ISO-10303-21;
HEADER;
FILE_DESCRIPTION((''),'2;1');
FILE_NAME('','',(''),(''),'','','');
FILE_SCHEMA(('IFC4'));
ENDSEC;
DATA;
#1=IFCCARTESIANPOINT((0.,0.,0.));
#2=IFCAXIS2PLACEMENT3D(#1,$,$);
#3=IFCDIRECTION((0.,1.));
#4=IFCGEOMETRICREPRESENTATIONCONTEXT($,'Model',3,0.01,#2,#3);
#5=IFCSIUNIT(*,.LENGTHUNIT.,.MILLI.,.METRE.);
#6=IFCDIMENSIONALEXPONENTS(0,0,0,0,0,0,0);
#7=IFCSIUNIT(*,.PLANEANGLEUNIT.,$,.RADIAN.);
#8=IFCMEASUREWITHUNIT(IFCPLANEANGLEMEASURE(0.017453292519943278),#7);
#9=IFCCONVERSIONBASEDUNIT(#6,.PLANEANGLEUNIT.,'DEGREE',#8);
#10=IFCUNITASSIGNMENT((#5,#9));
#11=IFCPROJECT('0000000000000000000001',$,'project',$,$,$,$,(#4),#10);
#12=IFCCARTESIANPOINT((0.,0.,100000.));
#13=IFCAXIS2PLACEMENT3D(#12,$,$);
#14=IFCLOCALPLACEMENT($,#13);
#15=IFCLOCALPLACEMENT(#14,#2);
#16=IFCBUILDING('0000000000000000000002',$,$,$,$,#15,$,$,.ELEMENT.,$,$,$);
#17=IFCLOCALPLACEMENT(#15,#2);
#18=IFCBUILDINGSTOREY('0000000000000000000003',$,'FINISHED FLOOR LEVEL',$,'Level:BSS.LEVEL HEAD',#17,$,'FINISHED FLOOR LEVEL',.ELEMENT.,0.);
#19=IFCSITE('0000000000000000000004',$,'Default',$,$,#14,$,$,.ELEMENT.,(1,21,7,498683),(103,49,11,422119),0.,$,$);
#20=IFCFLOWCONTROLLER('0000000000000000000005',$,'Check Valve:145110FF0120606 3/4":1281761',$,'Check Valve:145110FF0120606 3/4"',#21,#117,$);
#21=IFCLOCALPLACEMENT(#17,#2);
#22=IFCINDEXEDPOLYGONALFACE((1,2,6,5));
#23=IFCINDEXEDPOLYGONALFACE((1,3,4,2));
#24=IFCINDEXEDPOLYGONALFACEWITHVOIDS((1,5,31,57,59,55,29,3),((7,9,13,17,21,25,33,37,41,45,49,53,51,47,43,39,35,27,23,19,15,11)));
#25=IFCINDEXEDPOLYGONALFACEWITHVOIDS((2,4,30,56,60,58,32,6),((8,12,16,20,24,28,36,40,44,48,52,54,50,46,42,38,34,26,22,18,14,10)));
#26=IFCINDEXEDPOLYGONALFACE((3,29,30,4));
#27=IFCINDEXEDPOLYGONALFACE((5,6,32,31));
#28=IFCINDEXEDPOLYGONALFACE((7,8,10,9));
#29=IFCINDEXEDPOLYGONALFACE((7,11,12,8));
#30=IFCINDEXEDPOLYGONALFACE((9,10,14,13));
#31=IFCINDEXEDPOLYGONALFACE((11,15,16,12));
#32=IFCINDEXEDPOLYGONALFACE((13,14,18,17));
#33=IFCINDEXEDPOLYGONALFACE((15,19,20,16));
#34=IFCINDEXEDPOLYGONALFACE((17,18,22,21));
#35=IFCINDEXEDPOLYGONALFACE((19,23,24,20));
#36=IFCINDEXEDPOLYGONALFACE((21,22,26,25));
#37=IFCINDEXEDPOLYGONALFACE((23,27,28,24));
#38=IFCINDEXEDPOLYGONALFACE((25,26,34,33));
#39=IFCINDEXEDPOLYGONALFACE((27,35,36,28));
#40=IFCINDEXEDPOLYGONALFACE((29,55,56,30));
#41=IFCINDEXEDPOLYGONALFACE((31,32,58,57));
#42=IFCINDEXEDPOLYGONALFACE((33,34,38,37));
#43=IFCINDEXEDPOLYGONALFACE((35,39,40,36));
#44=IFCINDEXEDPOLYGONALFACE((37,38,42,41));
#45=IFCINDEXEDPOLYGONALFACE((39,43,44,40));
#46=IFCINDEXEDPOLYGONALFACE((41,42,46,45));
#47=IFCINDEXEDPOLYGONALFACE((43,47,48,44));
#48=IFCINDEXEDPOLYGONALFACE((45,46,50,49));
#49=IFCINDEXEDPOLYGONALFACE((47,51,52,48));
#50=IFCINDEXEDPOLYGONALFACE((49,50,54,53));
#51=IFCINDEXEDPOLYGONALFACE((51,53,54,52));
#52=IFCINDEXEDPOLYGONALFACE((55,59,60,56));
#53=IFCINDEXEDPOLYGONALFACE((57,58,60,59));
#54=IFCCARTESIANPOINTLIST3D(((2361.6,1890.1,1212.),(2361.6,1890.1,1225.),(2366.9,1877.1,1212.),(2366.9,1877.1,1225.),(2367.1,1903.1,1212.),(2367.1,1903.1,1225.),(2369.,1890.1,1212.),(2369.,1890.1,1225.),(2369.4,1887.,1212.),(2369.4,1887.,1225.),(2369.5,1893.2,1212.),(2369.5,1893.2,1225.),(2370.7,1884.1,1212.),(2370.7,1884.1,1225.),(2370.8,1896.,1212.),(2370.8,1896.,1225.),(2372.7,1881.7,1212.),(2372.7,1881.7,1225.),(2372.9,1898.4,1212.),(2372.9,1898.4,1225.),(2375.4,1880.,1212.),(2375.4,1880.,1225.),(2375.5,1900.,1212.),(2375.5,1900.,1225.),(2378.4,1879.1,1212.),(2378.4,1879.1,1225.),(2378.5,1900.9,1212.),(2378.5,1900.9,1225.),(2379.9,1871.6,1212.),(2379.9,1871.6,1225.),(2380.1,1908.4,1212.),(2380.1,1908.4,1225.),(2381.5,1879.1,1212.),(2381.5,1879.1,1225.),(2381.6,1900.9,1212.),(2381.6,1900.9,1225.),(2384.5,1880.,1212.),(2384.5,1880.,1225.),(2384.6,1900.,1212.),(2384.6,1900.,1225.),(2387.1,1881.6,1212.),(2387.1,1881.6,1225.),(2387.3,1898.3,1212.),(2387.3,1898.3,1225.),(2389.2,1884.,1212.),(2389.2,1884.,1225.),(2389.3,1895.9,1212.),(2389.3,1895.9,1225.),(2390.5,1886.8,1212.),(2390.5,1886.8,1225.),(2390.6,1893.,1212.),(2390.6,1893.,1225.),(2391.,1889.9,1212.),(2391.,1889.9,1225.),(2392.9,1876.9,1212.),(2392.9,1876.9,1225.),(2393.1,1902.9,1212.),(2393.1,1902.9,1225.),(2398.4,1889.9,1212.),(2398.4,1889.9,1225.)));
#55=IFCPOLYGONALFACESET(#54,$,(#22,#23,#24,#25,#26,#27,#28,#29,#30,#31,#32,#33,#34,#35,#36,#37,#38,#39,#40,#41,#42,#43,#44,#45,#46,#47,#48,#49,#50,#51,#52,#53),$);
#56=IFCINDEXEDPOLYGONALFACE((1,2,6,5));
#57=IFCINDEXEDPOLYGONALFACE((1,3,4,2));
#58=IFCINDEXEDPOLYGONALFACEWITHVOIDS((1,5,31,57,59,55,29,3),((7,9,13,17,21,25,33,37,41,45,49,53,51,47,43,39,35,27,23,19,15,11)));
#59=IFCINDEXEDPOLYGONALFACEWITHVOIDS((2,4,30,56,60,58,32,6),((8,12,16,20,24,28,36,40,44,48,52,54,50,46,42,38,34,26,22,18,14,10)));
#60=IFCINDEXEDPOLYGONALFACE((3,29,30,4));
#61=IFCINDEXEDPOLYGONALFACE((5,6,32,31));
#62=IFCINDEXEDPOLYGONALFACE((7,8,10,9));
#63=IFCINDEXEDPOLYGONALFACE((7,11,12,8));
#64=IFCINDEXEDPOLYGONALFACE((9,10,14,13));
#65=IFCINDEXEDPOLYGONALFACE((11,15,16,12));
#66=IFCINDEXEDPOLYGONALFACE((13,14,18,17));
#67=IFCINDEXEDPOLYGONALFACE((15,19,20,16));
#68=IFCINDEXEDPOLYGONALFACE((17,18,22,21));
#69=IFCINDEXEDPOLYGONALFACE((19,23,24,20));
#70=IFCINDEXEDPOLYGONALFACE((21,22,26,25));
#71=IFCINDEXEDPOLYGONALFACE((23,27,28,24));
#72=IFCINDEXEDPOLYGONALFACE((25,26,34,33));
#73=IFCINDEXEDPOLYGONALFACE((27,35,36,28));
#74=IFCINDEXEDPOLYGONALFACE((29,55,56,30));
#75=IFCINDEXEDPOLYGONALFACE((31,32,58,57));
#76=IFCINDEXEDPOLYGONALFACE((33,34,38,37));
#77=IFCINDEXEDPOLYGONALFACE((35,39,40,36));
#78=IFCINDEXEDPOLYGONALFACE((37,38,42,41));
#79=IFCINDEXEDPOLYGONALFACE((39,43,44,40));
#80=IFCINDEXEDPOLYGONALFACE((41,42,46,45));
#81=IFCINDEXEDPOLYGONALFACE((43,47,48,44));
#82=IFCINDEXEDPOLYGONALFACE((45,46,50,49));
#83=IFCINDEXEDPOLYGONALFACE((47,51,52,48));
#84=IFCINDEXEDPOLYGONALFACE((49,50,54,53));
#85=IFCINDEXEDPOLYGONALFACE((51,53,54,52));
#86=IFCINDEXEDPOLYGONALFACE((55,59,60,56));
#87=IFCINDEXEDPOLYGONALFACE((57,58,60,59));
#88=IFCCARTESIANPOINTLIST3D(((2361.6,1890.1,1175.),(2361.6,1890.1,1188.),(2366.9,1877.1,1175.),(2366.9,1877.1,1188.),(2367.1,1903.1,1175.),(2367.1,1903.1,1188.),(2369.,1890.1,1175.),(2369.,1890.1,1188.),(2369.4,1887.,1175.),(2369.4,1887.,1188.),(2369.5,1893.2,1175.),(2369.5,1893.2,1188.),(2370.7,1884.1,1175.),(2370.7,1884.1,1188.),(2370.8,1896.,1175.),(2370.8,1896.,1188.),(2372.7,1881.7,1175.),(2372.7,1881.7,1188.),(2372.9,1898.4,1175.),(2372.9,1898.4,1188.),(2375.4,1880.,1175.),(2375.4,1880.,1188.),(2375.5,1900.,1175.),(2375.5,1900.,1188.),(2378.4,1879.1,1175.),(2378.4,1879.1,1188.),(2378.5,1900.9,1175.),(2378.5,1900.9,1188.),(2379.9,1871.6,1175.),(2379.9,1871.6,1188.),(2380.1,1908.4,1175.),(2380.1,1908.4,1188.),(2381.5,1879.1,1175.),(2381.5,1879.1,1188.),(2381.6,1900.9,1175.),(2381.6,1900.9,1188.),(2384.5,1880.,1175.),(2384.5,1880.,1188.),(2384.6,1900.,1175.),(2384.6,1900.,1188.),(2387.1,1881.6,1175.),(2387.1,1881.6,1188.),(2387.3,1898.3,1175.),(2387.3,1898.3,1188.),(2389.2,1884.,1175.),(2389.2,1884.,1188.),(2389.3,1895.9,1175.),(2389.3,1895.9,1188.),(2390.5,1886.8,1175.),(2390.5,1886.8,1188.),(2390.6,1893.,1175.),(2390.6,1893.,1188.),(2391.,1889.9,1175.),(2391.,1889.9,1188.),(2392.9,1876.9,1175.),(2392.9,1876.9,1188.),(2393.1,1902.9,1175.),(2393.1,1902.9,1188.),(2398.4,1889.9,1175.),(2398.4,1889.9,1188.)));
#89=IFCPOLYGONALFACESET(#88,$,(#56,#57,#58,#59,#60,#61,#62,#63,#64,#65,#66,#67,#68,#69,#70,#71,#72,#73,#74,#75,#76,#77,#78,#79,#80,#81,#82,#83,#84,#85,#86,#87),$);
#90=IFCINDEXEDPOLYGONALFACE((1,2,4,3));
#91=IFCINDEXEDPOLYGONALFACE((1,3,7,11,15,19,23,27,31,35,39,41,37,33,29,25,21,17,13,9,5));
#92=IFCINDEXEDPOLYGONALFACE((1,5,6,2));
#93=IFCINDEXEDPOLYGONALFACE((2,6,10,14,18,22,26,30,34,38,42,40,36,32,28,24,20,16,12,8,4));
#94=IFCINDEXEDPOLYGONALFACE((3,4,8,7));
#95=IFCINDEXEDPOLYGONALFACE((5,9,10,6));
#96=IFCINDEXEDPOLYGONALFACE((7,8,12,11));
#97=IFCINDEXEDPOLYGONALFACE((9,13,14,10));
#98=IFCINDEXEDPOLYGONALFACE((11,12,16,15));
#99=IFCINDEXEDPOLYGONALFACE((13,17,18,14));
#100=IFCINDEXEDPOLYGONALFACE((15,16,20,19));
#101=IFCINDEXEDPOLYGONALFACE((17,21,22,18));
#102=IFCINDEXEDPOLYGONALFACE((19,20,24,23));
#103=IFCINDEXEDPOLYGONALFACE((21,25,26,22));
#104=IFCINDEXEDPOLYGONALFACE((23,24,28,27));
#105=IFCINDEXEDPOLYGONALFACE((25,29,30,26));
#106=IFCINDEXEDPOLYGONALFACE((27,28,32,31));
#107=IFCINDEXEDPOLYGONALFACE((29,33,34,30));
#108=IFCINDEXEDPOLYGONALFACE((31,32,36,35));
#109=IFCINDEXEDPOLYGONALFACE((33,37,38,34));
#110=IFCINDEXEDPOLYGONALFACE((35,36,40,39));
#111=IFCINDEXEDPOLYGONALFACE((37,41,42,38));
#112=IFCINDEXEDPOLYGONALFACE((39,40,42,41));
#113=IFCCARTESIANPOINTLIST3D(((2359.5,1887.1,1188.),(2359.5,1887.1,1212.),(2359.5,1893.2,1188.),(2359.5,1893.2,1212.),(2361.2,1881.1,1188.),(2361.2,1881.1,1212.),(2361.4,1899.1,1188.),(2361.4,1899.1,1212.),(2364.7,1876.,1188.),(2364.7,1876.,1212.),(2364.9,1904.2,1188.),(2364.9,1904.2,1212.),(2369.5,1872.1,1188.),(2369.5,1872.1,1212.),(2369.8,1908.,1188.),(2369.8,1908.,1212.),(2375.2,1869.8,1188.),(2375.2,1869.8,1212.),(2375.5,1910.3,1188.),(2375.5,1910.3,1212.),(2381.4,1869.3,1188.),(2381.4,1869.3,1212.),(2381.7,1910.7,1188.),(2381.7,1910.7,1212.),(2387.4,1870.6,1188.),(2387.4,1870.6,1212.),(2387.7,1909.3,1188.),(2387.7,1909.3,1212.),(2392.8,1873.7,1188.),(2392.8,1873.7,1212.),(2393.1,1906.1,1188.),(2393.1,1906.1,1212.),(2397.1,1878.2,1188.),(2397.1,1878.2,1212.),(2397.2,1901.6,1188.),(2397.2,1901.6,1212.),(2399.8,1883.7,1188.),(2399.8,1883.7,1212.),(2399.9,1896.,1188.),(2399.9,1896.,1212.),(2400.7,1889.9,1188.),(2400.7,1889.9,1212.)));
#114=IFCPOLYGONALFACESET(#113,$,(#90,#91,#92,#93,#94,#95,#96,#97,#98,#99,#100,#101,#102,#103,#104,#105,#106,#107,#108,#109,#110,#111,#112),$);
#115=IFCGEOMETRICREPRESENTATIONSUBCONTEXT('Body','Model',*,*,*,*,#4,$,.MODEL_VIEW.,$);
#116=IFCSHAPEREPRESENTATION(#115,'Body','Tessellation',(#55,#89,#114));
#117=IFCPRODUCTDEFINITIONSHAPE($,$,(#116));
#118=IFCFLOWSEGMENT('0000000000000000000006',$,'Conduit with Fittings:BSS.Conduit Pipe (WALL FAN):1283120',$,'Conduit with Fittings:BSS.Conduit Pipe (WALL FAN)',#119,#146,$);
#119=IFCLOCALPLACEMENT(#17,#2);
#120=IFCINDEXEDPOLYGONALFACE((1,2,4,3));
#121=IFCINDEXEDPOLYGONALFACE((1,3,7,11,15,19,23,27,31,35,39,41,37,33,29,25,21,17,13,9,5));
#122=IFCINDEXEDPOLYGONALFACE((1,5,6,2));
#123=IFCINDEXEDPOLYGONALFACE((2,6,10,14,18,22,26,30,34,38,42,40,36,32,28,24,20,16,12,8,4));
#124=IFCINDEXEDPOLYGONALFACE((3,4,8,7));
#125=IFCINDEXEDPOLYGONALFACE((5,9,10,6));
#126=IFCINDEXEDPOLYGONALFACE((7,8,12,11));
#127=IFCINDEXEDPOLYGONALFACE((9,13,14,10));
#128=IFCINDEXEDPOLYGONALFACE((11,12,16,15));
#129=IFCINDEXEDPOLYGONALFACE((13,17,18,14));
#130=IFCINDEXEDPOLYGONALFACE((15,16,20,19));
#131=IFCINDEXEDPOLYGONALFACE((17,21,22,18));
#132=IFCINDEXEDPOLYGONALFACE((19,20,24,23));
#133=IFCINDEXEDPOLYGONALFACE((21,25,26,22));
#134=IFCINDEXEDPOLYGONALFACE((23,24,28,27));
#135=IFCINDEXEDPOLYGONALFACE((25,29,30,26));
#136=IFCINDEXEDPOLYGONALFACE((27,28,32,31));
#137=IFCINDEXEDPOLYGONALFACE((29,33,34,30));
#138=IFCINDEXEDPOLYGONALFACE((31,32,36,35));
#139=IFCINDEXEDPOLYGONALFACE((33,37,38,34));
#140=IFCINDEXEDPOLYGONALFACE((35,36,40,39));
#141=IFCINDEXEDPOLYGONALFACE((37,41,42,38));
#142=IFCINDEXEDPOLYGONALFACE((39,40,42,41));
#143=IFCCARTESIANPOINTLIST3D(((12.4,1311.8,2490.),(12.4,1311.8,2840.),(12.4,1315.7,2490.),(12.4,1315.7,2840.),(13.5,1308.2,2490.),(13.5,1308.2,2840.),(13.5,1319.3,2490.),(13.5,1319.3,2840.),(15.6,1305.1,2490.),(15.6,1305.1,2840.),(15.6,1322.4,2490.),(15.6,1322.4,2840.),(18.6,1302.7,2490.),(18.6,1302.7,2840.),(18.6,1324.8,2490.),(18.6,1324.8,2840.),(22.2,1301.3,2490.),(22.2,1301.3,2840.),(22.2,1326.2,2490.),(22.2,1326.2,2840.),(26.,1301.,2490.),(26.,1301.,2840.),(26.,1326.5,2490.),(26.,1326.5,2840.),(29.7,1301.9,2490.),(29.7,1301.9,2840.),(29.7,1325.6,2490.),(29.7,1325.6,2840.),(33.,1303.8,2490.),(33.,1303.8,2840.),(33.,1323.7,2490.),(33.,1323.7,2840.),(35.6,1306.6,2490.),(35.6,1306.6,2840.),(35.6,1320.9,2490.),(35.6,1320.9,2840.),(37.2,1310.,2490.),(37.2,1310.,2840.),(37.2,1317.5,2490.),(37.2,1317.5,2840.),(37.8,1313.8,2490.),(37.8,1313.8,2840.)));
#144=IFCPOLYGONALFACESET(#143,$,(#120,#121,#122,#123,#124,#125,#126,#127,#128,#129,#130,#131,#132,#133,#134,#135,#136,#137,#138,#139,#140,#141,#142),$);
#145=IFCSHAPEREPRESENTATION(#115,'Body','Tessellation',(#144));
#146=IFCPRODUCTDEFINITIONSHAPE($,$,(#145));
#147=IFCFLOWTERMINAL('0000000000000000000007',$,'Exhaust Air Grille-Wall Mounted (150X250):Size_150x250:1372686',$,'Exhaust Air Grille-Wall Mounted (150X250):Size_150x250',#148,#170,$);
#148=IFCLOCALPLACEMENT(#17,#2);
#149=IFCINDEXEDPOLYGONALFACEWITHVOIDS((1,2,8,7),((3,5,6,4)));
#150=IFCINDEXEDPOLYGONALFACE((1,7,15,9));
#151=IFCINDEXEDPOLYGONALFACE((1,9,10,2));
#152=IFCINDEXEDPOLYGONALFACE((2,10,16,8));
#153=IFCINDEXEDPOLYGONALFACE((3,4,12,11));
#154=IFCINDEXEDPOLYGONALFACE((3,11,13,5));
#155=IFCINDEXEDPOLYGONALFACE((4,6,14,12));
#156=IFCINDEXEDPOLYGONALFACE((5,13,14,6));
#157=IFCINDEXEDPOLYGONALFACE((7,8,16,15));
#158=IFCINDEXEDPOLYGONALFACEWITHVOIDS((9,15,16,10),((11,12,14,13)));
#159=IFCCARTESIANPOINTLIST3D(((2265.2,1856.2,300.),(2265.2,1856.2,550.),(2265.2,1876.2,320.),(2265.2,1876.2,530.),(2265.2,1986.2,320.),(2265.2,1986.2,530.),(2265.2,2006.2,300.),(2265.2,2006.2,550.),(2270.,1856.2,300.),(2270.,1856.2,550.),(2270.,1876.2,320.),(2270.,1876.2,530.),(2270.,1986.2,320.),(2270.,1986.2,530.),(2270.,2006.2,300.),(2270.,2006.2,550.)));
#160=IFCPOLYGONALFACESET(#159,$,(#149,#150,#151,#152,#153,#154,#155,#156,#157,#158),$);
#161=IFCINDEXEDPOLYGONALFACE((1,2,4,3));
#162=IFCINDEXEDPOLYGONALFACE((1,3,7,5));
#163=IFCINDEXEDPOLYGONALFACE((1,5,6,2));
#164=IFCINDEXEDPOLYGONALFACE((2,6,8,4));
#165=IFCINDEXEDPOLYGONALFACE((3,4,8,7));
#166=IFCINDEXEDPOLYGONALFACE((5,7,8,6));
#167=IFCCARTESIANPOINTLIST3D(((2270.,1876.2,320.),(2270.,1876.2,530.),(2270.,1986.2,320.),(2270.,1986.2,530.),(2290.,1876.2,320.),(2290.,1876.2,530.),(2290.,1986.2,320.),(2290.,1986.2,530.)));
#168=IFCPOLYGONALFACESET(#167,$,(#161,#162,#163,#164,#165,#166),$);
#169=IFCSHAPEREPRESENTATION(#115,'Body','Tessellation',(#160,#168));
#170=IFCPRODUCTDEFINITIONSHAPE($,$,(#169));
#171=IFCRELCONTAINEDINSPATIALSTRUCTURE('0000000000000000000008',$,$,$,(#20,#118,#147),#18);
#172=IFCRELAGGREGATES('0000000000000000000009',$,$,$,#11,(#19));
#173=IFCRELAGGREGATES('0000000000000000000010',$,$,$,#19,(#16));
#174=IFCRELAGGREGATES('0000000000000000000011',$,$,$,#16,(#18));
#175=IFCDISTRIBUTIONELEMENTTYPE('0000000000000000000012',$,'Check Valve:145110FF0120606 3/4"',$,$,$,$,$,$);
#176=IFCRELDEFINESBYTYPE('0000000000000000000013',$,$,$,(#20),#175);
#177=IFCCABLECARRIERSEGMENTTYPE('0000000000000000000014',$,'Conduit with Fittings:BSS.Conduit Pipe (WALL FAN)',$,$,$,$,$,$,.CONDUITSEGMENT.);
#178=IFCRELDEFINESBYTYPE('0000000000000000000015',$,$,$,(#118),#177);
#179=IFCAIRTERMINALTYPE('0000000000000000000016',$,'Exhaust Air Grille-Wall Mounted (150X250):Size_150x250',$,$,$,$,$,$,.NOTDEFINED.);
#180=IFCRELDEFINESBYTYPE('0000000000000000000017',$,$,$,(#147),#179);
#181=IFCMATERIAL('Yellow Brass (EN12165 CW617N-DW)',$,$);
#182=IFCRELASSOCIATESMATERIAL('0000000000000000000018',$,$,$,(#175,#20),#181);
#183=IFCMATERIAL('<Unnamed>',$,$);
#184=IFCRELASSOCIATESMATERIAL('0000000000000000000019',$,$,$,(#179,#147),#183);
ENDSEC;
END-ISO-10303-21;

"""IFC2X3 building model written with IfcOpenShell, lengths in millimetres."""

from ifc_helpers import new_model, entity, si_unit, converted_unit, direction, frame, frame_2d, origin, origin_2d_with_axis, place, context, subcontext, project, spatial, polyline, circle_curve, parameter, trimmed, segment, composite_curve, rectangle, circle, outline, extrude, source, transform, mapped, material, type_object, type_shapes, element, save


model = new_model("IFC2X3")

# Units and contexts
model_context = context("Model", 3, precision=0.01, world=origin(), true_north=direction((0.0, 1.0)))
body_context = subcontext(model_context, "Body", "Model", "MODEL_VIEW")
ifc_project = project(units=[si_unit("LENGTHUNIT", "METRE", prefix="MILLI"), converted_unit("PLANEANGLEUNIT", "DEGREE", entity("IfcPlaneAngleMeasure", 0.017453292519943278), si_unit("PLANEANGLEUNIT", "RADIAN"), dimensions=[0, 0, 0, 0, 0, 0, 0])], contexts=[model_context])

# Site, building, storey
site_placement = place(None, frame((0.0, 0.0, 100000.0)))
site = spatial("IfcSite", under=ifc_project, at=site_placement, Name="Default", CompositionType="ELEMENT", RefLatitude=(1, 21, 7, 498683), RefLongitude=(103, 49, 11, 422119), RefElevation=0.0)
building_placement = place(site_placement, origin())
building = spatial("IfcBuilding", under=site, at=building_placement, CompositionType="ELEMENT")
storey_placement = place(building_placement, origin())
storey = spatial("IfcBuildingStorey", under=building, at=storey_placement, Name="FINISHED FLOOR LEVEL", ObjectType="Level:BSS.LEVEL HEAD", LongName="FINISHED FLOOR LEVEL", CompositionType="ELEMENT", Elevation=0.0)

# Shared definitions
ifc_material_1 = material(Name="<Unnamed>")

# Flow controller
ifc_material_2 = material(Name="Yellow Brass (EN12165 CW617N-DW)")
distribution_element_type_1 = type_object("IfcDistributionElementType", Name="Check Valve:145110FF0120606 3/4\"", material=ifc_material_2)
shared_shape_1 = source(origin(), body_context, "Body", "SweptSolid", [
    extrude(outline(polyline([(-7.0, -17.0), (7.0, -17.0), (17.0, -7.0), (17.0, 7.0), (7.0, 17.0), (-7.0, 17.0), (-17.0, 7.0), (-17.0, -7.0), (-7.0, -17.0)]), holes=[composite_curve([segment(trimmed(circle_curve(frame_2d((0.0, 0.0), x_axis=(-0.382683, 0.92388)), 11.0), [parameter(0.0)], [parameter(180.0)], True, "PARAMETER"), False, "CONTINUOUS"), segment(trimmed(circle_curve(frame_2d((0.0, 0.0), x_axis=(-0.382683, 0.92388)), 11.0), [parameter(180.0)], [parameter(0.0)], True, "PARAMETER"), False, "CONTINUOUS")], self_intersect=False)]), frame((-25.0, 0.0, 0.0), z_axis=(1.0, 0.0, 0.0), x_axis=(0.0, -0.382683, -0.92388)), (0.0, 0.0, 1.0), 13.0),
    extrude(outline(polyline([(-7.0, -17.0), (7.0, -17.0), (17.0, -7.0), (17.0, 7.0), (7.0, 17.0), (-7.0, 17.0), (-17.0, 7.0), (-17.0, -7.0), (-7.0, -17.0)]), holes=[composite_curve([segment(trimmed(circle_curve(frame_2d((0.0, 0.0), x_axis=(-0.382683, 0.92388)), 11.0), [parameter(0.0)], [parameter(180.0)], True, "PARAMETER"), False, "CONTINUOUS"), segment(trimmed(circle_curve(frame_2d((0.0, 0.0), x_axis=(-0.382683, 0.92388)), 11.0), [parameter(180.0)], [parameter(0.0)], True, "PARAMETER"), False, "CONTINUOUS")], self_intersect=False)]), frame((12.0, 0.0, 0.0), z_axis=(1.0, 0.0, 0.0), x_axis=(0.0, -0.382683, -0.92388)), (0.0, 0.0, 1.0), 13.0),
    extrude(circle(Radius=20.8, at=frame_2d((0.0, 0.0), x_axis=(1.0, 0.0))), frame((-12.0, 0.0, 0.0), z_axis=(1.0, 0.0, 0.0), x_axis=(0.0, 1.0, 0.0)), (0.0, 0.0, 1.0), 24.0),
])
type_shapes(distribution_element_type_1, [shared_shape_1])
flow_controller_placement = place(storey_placement, frame((2380.0, 1890.0, 1200.0), z_axis=(-0.007029, -0.999975, 0.0), x_axis=(0.0, 0.0, -1.0)))
element("IfcFlowController", 1, at=flow_controller_placement, inside=storey, type_object=distribution_element_type_1, material=ifc_material_2, Name="Check Valve:145110FF0120606 3/4\":1281761", ObjectType="Check Valve:145110FF0120606 3/4\"", context=body_context, shape_type="MappedRepresentation", body=[
    mapped(shared_shape_1, transform((0.0, 0.0, 0.0), scale=1.0)),
])

# Flow segment
cable_carrier_segment_type_1 = type_object("IfcCableCarrierSegmentType", Name="Conduit with Fittings:BSS.Conduit Pipe (WALL FAN)", PredefinedType="CONDUITSEGMENT")
flow_segment_1_placement = place(storey_placement, origin())
element("IfcFlowSegment", 2, at=flow_segment_1_placement, inside=storey, type_object=cable_carrier_segment_type_1, Name="Conduit with Fittings:BSS.Conduit Pipe (WALL FAN):1283120", ObjectType="Conduit with Fittings:BSS.Conduit Pipe (WALL FAN)", context=body_context, shape_type="SweptSolid", body=[
    extrude(circle(Radius=12.8, at=frame_2d((0.0, 0.0), x_axis=(1.0, 0.0))), frame((25.0, 1313.8, 2490.0)), (0.0, 0.0, 1.0), 350.0),
])

# Flow terminal
air_terminal_type_1 = type_object("IfcAirTerminalType", Name="Exhaust Air Grille-Wall Mounted (150X250):Size_150x250", PredefinedType="NOTDEFINED", material=ifc_material_1)
shared_shape_2 = source(origin(), body_context, "Body", "SweptSolid", [
    extrude(outline(polyline([(-125.0, -75.0), (125.0, -75.0), (125.0, 75.0), (-125.0, 75.0), (-125.0, -75.0)]), holes=[polyline([(-105.0, -55.0), (-105.0, 55.0), (105.0, 55.0), (105.0, -55.0), (-105.0, -55.0)])]), frame((0.0, -4.8, 0.0), z_axis=(0.0, 1.0, 0.0), x_axis=(0.0, 0.0, -1.0)), (0.0, 0.0, 1.0), 4.8),
    extrude(rectangle(XDim=20.0, YDim=110.0, at=origin_2d_with_axis()), frame((0.0, 10.0, -105.0), z_axis=(0.0, 0.0, 1.0), x_axis=(0.0, 1.0, 0.0)), (0.0, 0.0, 1.0), 210.0),
])
type_shapes(air_terminal_type_1, [shared_shape_2])
flow_terminal_1_placement = place(storey_placement, frame((2270.0, 1931.2, 425.0), z_axis=(0.0, 0.0, 1.0), x_axis=(0.0, -1.0, 0.0)))
element("IfcFlowTerminal", 3, at=flow_terminal_1_placement, inside=storey, type_object=air_terminal_type_1, material=ifc_material_1, Name="Exhaust Air Grille-Wall Mounted (150X250):Size_150x250:1372686", ObjectType="Exhaust Air Grille-Wall Mounted (150X250):Size_150x250", context=body_context, shape_type="MappedRepresentation", body=[
    mapped(shared_shape_2, transform((0.0, 0.0, 0.0), scale=1.0)),
])

save(model, "model.ifc")
